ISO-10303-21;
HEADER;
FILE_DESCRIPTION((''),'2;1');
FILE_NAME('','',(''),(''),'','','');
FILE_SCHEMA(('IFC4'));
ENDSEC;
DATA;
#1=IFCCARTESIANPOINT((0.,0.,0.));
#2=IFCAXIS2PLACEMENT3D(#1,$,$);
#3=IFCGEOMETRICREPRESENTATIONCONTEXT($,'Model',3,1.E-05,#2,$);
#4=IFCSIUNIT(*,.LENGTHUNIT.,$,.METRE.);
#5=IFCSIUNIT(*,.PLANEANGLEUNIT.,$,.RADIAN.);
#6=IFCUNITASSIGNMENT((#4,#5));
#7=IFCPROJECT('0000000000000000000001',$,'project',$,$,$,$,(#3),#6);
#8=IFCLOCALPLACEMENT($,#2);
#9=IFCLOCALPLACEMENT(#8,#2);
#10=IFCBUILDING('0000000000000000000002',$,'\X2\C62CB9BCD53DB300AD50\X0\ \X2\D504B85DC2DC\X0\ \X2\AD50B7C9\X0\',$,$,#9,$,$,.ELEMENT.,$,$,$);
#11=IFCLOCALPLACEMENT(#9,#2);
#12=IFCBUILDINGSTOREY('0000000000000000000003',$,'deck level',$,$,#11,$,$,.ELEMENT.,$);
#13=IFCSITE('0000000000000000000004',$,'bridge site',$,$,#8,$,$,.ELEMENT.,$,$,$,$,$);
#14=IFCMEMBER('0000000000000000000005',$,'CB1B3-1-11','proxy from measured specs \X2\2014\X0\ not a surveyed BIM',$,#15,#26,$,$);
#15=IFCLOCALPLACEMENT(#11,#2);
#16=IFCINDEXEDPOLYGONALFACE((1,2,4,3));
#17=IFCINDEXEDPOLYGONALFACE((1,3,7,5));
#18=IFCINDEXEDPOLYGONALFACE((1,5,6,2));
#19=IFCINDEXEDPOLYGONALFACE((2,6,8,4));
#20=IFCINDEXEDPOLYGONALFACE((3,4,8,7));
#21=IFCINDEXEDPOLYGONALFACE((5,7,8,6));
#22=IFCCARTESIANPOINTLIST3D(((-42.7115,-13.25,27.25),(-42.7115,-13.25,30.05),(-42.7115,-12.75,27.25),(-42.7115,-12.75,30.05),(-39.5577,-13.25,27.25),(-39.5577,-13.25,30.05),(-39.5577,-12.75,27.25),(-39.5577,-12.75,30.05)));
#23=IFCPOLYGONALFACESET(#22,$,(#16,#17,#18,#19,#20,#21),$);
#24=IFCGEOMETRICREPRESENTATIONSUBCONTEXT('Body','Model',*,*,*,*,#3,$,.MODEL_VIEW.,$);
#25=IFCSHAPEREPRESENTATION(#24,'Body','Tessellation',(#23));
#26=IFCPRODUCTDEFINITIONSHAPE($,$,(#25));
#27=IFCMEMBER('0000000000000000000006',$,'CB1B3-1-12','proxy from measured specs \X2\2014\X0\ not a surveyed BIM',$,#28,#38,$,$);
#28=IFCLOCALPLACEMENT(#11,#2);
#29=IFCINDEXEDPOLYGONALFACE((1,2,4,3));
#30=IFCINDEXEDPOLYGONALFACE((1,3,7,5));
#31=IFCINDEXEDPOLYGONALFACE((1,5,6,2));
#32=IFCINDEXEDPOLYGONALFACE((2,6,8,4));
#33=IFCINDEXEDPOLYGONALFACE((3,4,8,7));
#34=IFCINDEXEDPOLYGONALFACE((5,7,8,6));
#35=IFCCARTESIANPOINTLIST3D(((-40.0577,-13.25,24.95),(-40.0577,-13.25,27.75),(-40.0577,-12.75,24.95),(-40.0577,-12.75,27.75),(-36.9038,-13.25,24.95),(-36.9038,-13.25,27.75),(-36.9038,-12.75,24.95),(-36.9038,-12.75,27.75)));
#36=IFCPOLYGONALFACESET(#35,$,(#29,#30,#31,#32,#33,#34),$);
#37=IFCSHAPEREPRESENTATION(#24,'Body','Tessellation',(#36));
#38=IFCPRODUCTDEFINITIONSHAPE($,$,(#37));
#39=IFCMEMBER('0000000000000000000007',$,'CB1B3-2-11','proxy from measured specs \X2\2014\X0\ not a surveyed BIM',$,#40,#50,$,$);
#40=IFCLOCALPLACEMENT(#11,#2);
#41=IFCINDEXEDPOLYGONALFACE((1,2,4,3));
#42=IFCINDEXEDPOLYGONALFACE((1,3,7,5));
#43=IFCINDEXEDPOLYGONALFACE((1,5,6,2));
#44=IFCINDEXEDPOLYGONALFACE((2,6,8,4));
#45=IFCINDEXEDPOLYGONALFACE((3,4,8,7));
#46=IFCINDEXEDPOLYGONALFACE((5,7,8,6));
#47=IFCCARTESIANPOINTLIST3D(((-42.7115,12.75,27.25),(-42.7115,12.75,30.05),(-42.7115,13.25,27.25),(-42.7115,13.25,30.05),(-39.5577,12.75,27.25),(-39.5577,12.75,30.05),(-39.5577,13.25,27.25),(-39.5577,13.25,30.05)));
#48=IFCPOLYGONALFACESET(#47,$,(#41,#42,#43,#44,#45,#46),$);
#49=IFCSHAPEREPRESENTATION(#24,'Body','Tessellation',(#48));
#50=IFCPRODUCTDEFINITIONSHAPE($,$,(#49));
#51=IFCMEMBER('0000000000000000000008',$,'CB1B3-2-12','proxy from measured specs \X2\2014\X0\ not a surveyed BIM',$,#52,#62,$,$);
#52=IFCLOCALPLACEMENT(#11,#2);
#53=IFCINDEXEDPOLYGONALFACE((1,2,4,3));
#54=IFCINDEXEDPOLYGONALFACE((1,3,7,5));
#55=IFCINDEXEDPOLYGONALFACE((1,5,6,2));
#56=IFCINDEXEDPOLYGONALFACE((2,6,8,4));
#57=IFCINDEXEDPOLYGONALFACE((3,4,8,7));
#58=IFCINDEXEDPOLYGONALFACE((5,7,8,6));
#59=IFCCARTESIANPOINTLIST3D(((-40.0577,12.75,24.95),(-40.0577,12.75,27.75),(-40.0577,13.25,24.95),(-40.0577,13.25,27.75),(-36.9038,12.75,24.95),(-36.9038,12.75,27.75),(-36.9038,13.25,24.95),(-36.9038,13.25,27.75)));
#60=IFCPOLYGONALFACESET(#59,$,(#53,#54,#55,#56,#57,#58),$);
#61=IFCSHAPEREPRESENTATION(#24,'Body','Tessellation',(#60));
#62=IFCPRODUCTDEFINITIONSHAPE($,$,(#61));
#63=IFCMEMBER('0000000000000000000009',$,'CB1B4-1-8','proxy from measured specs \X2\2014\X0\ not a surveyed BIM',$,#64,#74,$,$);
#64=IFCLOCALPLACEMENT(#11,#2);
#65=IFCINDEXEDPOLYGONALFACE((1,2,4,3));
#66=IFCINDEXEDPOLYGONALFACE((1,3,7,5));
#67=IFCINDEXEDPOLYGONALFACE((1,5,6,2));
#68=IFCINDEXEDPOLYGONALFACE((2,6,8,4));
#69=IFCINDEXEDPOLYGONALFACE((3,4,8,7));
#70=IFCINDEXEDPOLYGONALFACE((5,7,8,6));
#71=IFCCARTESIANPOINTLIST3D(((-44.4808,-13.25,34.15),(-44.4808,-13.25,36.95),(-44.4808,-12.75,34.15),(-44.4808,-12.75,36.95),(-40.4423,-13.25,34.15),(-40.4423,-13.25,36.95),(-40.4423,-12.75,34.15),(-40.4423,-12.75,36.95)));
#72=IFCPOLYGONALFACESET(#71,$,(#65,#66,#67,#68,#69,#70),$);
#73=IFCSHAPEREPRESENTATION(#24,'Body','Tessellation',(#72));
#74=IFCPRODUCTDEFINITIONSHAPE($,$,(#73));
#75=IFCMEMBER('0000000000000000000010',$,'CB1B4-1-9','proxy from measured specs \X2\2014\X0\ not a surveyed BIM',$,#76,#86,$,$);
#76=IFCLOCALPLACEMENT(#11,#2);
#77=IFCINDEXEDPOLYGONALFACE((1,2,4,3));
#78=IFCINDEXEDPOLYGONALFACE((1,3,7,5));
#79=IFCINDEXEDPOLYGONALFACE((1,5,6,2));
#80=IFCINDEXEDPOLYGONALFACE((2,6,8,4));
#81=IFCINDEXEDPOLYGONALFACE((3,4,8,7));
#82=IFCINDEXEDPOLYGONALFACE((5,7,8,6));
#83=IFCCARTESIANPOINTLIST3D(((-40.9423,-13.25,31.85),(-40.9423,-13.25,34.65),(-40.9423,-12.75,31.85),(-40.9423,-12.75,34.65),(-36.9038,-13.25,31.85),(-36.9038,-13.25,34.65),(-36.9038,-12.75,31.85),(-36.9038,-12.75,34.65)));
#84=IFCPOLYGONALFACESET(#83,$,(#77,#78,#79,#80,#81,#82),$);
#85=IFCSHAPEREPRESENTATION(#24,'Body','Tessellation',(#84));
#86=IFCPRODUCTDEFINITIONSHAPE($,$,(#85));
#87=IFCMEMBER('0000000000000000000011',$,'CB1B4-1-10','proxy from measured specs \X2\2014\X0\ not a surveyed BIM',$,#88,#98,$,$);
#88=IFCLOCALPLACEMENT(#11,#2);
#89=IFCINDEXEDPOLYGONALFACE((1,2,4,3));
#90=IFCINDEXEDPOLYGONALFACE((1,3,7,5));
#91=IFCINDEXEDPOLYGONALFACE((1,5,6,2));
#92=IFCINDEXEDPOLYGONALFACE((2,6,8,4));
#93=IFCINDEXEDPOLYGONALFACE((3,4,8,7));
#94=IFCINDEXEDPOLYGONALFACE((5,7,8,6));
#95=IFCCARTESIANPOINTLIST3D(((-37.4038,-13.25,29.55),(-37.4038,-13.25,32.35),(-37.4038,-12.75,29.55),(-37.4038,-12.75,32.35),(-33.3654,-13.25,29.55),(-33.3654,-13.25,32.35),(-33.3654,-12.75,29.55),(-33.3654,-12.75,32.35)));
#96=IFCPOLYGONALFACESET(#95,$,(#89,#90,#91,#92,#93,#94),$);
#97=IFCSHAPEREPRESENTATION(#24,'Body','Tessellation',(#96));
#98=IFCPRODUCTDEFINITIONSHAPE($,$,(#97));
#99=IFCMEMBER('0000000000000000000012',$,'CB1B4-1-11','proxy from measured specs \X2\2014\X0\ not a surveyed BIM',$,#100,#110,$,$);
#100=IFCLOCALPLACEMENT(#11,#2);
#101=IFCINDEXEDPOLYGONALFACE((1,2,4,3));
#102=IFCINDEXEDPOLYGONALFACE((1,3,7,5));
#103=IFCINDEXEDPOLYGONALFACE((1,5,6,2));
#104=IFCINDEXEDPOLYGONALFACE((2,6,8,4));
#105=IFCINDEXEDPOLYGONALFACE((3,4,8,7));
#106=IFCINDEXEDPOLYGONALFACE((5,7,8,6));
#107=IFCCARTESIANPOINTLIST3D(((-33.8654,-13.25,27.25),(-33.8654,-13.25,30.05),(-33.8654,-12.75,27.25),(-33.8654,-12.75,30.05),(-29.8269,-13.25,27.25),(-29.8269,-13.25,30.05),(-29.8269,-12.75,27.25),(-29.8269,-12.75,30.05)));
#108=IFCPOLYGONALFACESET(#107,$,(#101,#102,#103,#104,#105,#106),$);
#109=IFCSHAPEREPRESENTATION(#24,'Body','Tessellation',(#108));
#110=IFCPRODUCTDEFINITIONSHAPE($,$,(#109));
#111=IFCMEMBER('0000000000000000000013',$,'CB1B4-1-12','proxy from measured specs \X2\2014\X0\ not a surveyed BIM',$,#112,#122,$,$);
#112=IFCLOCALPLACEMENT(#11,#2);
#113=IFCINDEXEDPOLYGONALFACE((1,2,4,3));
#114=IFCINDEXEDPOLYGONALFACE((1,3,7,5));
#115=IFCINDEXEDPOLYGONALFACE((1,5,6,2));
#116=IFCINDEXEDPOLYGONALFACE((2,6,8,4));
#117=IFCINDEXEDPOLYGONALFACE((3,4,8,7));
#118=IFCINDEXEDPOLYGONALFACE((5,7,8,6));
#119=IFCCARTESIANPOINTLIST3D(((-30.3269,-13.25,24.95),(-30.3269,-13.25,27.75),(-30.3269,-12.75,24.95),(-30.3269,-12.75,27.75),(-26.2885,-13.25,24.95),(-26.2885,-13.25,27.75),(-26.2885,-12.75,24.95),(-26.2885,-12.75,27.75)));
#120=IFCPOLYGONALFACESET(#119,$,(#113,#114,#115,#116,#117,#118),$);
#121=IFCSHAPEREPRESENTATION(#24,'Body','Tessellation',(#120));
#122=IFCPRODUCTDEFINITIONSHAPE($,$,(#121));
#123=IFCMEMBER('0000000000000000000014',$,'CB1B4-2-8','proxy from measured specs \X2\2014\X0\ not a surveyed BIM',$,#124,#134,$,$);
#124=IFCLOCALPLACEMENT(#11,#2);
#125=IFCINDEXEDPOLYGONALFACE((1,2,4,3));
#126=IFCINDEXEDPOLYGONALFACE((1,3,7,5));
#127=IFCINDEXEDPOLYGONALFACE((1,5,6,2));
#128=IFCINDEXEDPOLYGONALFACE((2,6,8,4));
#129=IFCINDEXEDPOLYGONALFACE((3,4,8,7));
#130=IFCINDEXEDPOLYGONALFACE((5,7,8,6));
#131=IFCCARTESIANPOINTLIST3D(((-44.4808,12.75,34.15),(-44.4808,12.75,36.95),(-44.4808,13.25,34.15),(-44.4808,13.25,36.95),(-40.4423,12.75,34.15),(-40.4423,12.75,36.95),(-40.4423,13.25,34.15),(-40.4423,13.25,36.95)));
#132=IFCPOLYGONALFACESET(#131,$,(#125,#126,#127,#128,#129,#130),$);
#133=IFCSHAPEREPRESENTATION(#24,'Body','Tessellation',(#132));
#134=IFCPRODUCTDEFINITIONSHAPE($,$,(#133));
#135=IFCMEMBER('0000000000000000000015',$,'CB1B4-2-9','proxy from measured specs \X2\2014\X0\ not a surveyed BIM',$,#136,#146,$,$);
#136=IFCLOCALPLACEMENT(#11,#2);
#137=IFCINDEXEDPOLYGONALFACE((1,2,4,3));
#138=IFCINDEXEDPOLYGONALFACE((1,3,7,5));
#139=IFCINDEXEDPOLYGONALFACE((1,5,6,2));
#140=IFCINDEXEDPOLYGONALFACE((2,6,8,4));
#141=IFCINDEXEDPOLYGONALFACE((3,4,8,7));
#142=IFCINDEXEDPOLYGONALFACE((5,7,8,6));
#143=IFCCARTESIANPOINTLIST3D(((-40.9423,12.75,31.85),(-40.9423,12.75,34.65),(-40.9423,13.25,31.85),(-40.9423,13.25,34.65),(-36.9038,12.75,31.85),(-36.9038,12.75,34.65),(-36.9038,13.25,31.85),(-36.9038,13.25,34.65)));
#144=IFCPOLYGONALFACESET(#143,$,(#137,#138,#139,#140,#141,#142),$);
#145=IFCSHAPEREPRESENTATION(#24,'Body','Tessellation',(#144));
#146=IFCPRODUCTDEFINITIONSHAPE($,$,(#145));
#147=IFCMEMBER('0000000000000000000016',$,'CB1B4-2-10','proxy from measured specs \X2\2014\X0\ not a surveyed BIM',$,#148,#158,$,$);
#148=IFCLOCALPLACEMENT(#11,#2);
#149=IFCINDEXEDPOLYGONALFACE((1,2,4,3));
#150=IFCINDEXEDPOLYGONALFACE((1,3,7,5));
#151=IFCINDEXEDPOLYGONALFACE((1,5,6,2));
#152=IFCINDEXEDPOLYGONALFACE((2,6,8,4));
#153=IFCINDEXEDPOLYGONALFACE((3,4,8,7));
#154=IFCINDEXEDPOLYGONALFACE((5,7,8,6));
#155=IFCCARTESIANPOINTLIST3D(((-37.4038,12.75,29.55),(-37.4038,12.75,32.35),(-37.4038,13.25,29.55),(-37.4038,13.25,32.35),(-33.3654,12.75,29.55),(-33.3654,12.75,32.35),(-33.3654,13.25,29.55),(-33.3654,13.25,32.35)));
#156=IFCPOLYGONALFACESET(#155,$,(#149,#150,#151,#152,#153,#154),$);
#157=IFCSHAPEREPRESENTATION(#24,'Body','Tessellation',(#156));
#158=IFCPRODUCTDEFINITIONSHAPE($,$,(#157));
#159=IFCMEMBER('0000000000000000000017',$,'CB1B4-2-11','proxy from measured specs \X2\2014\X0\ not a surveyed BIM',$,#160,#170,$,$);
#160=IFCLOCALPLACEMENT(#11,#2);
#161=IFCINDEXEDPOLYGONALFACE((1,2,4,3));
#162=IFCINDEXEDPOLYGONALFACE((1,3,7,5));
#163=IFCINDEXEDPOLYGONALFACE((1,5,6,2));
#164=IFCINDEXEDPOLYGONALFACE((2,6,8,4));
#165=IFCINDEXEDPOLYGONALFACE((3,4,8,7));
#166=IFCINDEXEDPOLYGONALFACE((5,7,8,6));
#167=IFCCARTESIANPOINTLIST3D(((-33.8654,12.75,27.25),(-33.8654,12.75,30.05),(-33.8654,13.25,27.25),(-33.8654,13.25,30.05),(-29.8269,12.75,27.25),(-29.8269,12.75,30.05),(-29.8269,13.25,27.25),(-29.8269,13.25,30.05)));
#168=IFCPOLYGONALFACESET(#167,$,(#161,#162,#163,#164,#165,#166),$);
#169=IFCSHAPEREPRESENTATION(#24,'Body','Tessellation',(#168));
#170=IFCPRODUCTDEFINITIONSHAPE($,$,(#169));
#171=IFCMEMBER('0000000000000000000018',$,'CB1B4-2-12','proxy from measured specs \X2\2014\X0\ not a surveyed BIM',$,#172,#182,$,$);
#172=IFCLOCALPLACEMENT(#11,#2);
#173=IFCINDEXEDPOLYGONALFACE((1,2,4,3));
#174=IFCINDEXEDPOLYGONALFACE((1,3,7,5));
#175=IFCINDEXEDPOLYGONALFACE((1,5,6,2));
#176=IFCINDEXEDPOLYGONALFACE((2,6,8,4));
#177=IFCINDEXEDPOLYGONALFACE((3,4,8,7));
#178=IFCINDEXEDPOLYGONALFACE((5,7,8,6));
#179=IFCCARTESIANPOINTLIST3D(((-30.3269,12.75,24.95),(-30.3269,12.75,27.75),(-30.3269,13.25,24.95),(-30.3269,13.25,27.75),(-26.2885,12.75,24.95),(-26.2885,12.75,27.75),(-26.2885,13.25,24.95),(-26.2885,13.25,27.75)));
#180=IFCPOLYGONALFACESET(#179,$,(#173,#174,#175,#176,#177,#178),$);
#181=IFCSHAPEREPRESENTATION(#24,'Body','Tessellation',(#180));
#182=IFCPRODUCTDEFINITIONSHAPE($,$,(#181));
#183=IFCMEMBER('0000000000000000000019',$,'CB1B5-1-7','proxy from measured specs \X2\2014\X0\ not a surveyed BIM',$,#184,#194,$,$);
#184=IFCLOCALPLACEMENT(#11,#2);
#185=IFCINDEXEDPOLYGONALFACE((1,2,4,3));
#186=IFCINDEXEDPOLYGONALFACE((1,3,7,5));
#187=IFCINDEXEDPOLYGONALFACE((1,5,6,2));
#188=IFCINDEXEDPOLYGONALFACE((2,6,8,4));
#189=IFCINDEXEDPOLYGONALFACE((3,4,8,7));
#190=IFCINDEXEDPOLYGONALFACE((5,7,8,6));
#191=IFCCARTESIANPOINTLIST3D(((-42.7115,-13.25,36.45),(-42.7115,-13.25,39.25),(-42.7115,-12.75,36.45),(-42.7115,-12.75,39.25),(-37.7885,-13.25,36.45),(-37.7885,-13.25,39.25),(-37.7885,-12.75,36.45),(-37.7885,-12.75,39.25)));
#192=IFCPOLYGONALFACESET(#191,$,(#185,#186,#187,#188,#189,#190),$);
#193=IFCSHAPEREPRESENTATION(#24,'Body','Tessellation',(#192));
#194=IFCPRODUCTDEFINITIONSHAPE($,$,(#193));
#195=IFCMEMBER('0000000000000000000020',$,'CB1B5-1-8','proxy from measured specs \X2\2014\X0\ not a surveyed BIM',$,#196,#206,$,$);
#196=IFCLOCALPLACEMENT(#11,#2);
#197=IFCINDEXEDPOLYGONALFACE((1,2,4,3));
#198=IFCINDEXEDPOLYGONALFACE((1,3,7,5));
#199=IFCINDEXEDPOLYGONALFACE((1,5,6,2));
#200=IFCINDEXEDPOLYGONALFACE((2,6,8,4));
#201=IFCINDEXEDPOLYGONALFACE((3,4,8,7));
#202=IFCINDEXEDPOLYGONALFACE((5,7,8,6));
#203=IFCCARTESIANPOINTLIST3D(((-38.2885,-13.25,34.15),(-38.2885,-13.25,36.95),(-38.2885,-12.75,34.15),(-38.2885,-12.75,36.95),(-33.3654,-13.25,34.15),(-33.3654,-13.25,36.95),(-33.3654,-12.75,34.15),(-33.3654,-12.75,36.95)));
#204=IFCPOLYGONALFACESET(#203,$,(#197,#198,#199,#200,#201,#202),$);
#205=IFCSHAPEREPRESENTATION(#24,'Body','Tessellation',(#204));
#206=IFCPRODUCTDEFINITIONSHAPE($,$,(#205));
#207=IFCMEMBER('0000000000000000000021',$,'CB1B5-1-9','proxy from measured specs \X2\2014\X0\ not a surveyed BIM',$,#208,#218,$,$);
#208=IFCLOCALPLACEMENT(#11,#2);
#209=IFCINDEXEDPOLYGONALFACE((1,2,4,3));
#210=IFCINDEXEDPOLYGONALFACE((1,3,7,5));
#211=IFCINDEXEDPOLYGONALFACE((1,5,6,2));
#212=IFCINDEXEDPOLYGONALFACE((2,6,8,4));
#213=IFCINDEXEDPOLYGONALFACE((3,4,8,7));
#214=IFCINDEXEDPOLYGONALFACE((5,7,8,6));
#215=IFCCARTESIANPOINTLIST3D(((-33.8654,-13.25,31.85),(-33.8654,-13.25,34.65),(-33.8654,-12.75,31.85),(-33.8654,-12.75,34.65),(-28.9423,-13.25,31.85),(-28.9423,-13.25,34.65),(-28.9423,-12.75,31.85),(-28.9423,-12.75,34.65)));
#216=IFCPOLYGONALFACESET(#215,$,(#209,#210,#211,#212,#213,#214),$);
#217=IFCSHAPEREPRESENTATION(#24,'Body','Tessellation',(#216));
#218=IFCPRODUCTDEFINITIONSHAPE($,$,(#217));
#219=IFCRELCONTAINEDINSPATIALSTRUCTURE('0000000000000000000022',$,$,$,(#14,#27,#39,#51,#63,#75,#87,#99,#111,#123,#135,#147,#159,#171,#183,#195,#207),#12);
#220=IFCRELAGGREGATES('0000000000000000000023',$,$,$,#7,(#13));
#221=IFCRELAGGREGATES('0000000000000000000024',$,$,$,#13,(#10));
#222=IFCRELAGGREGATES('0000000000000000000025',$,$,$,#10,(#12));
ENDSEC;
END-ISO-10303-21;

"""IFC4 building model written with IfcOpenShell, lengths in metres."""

from ifc_helpers import new_model, si_unit, frame, origin, origin_2d, place, context, subcontext, project, spatial, rectangle, extrude, element, save


model = new_model("IFC4")

# Units and contexts
model_context = context("Model", 3, precision=1e-05, world=origin())
body_context = subcontext(model_context, "Body", "Model", "MODEL_VIEW")
ifc_project = project(units=[si_unit("LENGTHUNIT", "METRE"), si_unit("PLANEANGLEUNIT", "RADIAN")], contexts=[model_context])

# Site, building, storey
site_placement = place(None, origin())
site = spatial("IfcSite", under=ifc_project, at=site_placement, Name="bridge site", CompositionType="ELEMENT")
building_placement = place(site_placement, origin())
building = spatial("IfcBuilding", under=site, at=building_placement, Name="올림픽대교 프록시 교량", CompositionType="ELEMENT")
storey_placement = place(building_placement, origin())
storey = spatial("IfcBuildingStorey", under=building, at=storey_placement, Name="deck level", CompositionType="ELEMENT")

# Members
member_1_placement = place(storey_placement, frame((-41.1346, -13.0, 27.25)))
element("IfcMember", 1, at=member_1_placement, inside=storey, Name="CB1B3-1-11", Description="proxy from measured specs — not a surveyed BIM", context=body_context, shape_type="SweptSolid", body=[
    extrude(rectangle(XDim=3.1538, YDim=0.5, at=origin_2d()), origin(), (0.0, 0.0, 1.0), 2.8),
])
member_2_placement = place(storey_placement, frame((-38.4808, -13.0, 24.95)))
element("IfcMember", 2, at=member_2_placement, inside=storey, Name="CB1B3-1-12", Description="proxy from measured specs — not a surveyed BIM", context=body_context, shape_type="SweptSolid", body=[
    extrude(rectangle(XDim=3.1538, YDim=0.5, at=origin_2d()), origin(), (0.0, 0.0, 1.0), 2.8),
])
member_3_placement = place(storey_placement, frame((-41.1346, 13.0, 27.25)))
element("IfcMember", 3, at=member_3_placement, inside=storey, Name="CB1B3-2-11", Description="proxy from measured specs — not a surveyed BIM", context=body_context, shape_type="SweptSolid", body=[
    extrude(rectangle(XDim=3.1538, YDim=0.5, at=origin_2d()), origin(), (0.0, 0.0, 1.0), 2.8),
])
member_4_placement = place(storey_placement, frame((-38.4808, 13.0, 24.95)))
element("IfcMember", 4, at=member_4_placement, inside=storey, Name="CB1B3-2-12", Description="proxy from measured specs — not a surveyed BIM", context=body_context, shape_type="SweptSolid", body=[
    extrude(rectangle(XDim=3.1538, YDim=0.5, at=origin_2d()), origin(), (0.0, 0.0, 1.0), 2.8),
])
for number, where, name in (
    (5, (-42.4615, -13.0, 34.15), "CB1B4-1-8"),
    (6, (-38.9231, -13.0, 31.85), "CB1B4-1-9"),
):
    element("IfcMember", number, at=place(storey_placement, frame(where)), inside=storey, Name=name, Description="proxy from measured specs — not a surveyed BIM", context=body_context, shape_type="SweptSolid", body=[
        extrude(rectangle(XDim=4.0385, YDim=0.5, at=origin_2d()), origin(), (0.0, 0.0, 1.0), 2.8),
    ])
for number, where, name in (
    (7, (-35.3846, -13.0, 29.55), "CB1B4-1-10"),
    (8, (-31.8462, -13.0, 27.25), "CB1B4-1-11"),
):
    element("IfcMember", number, at=place(storey_placement, frame(where)), inside=storey, Name=name, Description="proxy from measured specs — not a surveyed BIM", context=body_context, shape_type="SweptSolid", body=[
        extrude(rectangle(XDim=4.0385, YDim=0.5, at=origin_2d()), origin(), (0.0, 0.0, 1.0), 2.8),
    ])
member_5_placement = place(storey_placement, frame((-28.3077, -13.0, 24.95)))
element("IfcMember", 9, at=member_5_placement, inside=storey, Name="CB1B4-1-12", Description="proxy from measured specs — not a surveyed BIM", context=body_context, shape_type="SweptSolid", body=[
    extrude(rectangle(XDim=4.0385, YDim=0.5, at=origin_2d()), origin(), (0.0, 0.0, 1.0), 2.8),
])
for number, where, name in (
    (10, (-42.4615, 13.0, 34.15), "CB1B4-2-8"),
    (11, (-38.9231, 13.0, 31.85), "CB1B4-2-9"),
):
    element("IfcMember", number, at=place(storey_placement, frame(where)), inside=storey, Name=name, Description="proxy from measured specs — not a surveyed BIM", context=body_context, shape_type="SweptSolid", body=[
        extrude(rectangle(XDim=4.0385, YDim=0.5, at=origin_2d()), origin(), (0.0, 0.0, 1.0), 2.8),
    ])
for number, where, name in (
    (12, (-35.3846, 13.0, 29.55), "CB1B4-2-10"),
    (13, (-31.8462, 13.0, 27.25), "CB1B4-2-11"),
):
    element("IfcMember", number, at=place(storey_placement, frame(where)), inside=storey, Name=name, Description="proxy from measured specs — not a surveyed BIM", context=body_context, shape_type="SweptSolid", body=[
        extrude(rectangle(XDim=4.0385, YDim=0.5, at=origin_2d()), origin(), (0.0, 0.0, 1.0), 2.8),
    ])
member_6_placement = place(storey_placement, frame((-28.3077, 13.0, 24.95)))
element("IfcMember", 14, at=member_6_placement, inside=storey, Name="CB1B4-2-12", Description="proxy from measured specs — not a surveyed BIM", context=body_context, shape_type="SweptSolid", body=[
    extrude(rectangle(XDim=4.0385, YDim=0.5, at=origin_2d()), origin(), (0.0, 0.0, 1.0), 2.8),
])
member_7_placement = place(storey_placement, frame((-40.25, -13.0, 36.45)))
element("IfcMember", 15, at=member_7_placement, inside=storey, Name="CB1B5-1-7", Description="proxy from measured specs — not a surveyed BIM", context=body_context, shape_type="SweptSolid", body=[
    extrude(rectangle(XDim=4.9231, YDim=0.5, at=origin_2d()), origin(), (0.0, 0.0, 1.0), 2.8),
])
member_8_placement = place(storey_placement, frame((-35.8269, -13.0, 34.15)))
element("IfcMember", 16, at=member_8_placement, inside=storey, Name="CB1B5-1-8", Description="proxy from measured specs — not a surveyed BIM", context=body_context, shape_type="SweptSolid", body=[
    extrude(rectangle(XDim=4.9231, YDim=0.5, at=origin_2d()), origin(), (0.0, 0.0, 1.0), 2.8),
])
member_9_placement = place(storey_placement, frame((-31.4038, -13.0, 31.85)))
element("IfcMember", 17, at=member_9_placement, inside=storey, Name="CB1B5-1-9", Description="proxy from measured specs — not a surveyed BIM", context=body_context, shape_type="SweptSolid", body=[
    extrude(rectangle(XDim=4.9231, YDim=0.5, at=origin_2d()), origin(), (0.0, 0.0, 1.0), 2.8),
])

save(model, "model.ifc")
